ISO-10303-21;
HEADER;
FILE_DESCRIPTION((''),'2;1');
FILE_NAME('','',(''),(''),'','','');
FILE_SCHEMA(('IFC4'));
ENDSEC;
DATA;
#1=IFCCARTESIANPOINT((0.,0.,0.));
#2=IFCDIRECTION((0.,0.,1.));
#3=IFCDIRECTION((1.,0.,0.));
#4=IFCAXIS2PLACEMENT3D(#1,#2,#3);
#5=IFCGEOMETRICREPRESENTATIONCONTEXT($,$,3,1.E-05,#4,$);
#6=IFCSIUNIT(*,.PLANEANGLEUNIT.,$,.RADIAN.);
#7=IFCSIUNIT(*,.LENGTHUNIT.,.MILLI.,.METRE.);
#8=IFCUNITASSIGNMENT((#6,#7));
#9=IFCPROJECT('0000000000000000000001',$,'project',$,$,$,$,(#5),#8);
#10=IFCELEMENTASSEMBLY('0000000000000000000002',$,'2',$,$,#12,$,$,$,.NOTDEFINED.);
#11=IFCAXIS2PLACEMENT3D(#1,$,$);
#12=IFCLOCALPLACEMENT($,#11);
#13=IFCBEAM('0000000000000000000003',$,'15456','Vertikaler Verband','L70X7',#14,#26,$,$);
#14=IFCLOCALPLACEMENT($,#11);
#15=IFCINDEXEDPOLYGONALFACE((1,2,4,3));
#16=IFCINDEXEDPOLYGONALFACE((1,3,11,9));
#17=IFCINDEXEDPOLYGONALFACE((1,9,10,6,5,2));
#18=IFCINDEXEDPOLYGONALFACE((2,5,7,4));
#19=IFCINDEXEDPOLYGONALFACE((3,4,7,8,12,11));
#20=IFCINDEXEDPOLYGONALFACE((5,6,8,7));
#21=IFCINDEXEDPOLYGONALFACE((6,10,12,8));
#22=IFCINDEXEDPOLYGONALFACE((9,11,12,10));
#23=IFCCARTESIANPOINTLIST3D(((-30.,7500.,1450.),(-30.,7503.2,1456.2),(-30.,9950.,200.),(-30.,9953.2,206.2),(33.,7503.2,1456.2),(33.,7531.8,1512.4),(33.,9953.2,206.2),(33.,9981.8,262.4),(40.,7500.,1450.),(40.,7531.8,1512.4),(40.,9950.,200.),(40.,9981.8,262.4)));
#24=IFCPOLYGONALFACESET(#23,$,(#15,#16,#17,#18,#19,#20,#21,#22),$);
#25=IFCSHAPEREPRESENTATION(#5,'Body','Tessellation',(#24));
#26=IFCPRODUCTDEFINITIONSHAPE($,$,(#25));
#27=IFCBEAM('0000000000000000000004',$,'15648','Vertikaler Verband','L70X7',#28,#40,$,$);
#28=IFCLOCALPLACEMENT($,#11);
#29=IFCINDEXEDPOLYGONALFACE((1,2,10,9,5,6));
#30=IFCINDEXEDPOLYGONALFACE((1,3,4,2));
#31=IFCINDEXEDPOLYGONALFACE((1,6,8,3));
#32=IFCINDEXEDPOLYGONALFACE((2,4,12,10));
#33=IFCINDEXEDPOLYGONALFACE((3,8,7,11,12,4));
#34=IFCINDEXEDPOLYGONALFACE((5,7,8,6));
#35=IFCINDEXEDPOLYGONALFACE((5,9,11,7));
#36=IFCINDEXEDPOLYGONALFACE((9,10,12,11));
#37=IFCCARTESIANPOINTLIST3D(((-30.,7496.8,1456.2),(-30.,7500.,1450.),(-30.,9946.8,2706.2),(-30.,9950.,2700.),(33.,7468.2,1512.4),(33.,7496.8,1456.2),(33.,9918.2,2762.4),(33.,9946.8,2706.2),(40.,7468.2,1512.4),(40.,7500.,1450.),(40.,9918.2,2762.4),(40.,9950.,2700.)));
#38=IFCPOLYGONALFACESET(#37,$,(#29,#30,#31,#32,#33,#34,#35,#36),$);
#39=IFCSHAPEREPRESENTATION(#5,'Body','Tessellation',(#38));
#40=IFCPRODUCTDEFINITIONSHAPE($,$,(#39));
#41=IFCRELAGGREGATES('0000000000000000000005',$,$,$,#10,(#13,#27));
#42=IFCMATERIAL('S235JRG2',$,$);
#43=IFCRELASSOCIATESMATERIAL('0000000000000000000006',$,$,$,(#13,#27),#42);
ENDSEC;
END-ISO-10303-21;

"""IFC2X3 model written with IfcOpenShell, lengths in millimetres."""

from ifc_helpers import new_model, si_unit, frame, origin_with_axes, place, context, project, polyline, outline, extrude, material, element, aggregate, save


model = new_model("IFC2X3")

# Units and contexts
context_of_model = context(None, 3, precision=1e-05, world=origin_with_axes())
ifc_project = project(units=[si_unit("PLANEANGLEUNIT", "RADIAN"), si_unit("LENGTHUNIT", "METRE", prefix="MILLI")], contexts=[context_of_model])

# Shared definitions
ifc_material = material(Name="S235JRG2")

# Element assembly, beams
assembly_1_placement = place(None, frame((40.0, 7500.0, 1450.0), z_axis=(0.0, 0.45447, 0.890762), x_axis=(0.0, 0.890762, -0.45447)))
assembly_1 = element("IfcElementAssembly", 1, at=assembly_1_placement, Name="2", PredefinedType="NOTDEFINED")
placement_1 = place(None, frame((20.3, 7509.0, 1467.5), z_axis=(0.0, 0.45447, 0.890762), x_axis=(0.0, 0.890762, -0.45447)))
beam_1_placement = place(placement_1, origin_with_axes())
beam_1 = element("IfcBeam", 2, at=beam_1_placement, material=ifc_material, Name="15456", Description="Vertikaler Verband", ObjectType="L70X7", context=context_of_model, shape_type="SweptSolid", body=[
    extrude(outline(polyline([(-19.7, 50.3), (-19.7, -19.7), (50.3, -19.7), (50.3, -12.7), (-12.7, -12.7), (-12.7, 50.3), (-19.7, 50.3), (-19.7, 50.3)])), frame((0.0, 0.0, 0.0), z_axis=(1.0, 0.0, 0.0), x_axis=(0.0, 1.0, 0.0)), (0.0, 0.0, 1.0), 2750.5),
])
placement_2 = place(None, frame((20.3, 7491.0, 1467.5), z_axis=(0.0, -0.45447, 0.890762), x_axis=(0.0, 0.890762, 0.45447)))
beam_2_placement = place(placement_2, origin_with_axes())
beam_2 = element("IfcBeam", 3, at=beam_2_placement, material=ifc_material, Name="15648", Description="Vertikaler Verband", ObjectType="L70X7", context=context_of_model, shape_type="SweptSolid", body=[
    extrude(outline(polyline([(-19.7, 50.3), (-19.7, -19.7), (50.3, -19.7), (50.3, -12.7), (-12.7, -12.7), (-12.7, 50.3), (-19.7, 50.3), (-19.7, 50.3)])), frame((0.0, 0.0, 0.0), z_axis=(1.0, 0.0, 0.0), x_axis=(0.0, 1.0, 0.0)), (0.0, 0.0, 1.0), 2750.5),
])
aggregate(assembly_1, [beam_1, beam_2])

save(model, "model.ifc")
